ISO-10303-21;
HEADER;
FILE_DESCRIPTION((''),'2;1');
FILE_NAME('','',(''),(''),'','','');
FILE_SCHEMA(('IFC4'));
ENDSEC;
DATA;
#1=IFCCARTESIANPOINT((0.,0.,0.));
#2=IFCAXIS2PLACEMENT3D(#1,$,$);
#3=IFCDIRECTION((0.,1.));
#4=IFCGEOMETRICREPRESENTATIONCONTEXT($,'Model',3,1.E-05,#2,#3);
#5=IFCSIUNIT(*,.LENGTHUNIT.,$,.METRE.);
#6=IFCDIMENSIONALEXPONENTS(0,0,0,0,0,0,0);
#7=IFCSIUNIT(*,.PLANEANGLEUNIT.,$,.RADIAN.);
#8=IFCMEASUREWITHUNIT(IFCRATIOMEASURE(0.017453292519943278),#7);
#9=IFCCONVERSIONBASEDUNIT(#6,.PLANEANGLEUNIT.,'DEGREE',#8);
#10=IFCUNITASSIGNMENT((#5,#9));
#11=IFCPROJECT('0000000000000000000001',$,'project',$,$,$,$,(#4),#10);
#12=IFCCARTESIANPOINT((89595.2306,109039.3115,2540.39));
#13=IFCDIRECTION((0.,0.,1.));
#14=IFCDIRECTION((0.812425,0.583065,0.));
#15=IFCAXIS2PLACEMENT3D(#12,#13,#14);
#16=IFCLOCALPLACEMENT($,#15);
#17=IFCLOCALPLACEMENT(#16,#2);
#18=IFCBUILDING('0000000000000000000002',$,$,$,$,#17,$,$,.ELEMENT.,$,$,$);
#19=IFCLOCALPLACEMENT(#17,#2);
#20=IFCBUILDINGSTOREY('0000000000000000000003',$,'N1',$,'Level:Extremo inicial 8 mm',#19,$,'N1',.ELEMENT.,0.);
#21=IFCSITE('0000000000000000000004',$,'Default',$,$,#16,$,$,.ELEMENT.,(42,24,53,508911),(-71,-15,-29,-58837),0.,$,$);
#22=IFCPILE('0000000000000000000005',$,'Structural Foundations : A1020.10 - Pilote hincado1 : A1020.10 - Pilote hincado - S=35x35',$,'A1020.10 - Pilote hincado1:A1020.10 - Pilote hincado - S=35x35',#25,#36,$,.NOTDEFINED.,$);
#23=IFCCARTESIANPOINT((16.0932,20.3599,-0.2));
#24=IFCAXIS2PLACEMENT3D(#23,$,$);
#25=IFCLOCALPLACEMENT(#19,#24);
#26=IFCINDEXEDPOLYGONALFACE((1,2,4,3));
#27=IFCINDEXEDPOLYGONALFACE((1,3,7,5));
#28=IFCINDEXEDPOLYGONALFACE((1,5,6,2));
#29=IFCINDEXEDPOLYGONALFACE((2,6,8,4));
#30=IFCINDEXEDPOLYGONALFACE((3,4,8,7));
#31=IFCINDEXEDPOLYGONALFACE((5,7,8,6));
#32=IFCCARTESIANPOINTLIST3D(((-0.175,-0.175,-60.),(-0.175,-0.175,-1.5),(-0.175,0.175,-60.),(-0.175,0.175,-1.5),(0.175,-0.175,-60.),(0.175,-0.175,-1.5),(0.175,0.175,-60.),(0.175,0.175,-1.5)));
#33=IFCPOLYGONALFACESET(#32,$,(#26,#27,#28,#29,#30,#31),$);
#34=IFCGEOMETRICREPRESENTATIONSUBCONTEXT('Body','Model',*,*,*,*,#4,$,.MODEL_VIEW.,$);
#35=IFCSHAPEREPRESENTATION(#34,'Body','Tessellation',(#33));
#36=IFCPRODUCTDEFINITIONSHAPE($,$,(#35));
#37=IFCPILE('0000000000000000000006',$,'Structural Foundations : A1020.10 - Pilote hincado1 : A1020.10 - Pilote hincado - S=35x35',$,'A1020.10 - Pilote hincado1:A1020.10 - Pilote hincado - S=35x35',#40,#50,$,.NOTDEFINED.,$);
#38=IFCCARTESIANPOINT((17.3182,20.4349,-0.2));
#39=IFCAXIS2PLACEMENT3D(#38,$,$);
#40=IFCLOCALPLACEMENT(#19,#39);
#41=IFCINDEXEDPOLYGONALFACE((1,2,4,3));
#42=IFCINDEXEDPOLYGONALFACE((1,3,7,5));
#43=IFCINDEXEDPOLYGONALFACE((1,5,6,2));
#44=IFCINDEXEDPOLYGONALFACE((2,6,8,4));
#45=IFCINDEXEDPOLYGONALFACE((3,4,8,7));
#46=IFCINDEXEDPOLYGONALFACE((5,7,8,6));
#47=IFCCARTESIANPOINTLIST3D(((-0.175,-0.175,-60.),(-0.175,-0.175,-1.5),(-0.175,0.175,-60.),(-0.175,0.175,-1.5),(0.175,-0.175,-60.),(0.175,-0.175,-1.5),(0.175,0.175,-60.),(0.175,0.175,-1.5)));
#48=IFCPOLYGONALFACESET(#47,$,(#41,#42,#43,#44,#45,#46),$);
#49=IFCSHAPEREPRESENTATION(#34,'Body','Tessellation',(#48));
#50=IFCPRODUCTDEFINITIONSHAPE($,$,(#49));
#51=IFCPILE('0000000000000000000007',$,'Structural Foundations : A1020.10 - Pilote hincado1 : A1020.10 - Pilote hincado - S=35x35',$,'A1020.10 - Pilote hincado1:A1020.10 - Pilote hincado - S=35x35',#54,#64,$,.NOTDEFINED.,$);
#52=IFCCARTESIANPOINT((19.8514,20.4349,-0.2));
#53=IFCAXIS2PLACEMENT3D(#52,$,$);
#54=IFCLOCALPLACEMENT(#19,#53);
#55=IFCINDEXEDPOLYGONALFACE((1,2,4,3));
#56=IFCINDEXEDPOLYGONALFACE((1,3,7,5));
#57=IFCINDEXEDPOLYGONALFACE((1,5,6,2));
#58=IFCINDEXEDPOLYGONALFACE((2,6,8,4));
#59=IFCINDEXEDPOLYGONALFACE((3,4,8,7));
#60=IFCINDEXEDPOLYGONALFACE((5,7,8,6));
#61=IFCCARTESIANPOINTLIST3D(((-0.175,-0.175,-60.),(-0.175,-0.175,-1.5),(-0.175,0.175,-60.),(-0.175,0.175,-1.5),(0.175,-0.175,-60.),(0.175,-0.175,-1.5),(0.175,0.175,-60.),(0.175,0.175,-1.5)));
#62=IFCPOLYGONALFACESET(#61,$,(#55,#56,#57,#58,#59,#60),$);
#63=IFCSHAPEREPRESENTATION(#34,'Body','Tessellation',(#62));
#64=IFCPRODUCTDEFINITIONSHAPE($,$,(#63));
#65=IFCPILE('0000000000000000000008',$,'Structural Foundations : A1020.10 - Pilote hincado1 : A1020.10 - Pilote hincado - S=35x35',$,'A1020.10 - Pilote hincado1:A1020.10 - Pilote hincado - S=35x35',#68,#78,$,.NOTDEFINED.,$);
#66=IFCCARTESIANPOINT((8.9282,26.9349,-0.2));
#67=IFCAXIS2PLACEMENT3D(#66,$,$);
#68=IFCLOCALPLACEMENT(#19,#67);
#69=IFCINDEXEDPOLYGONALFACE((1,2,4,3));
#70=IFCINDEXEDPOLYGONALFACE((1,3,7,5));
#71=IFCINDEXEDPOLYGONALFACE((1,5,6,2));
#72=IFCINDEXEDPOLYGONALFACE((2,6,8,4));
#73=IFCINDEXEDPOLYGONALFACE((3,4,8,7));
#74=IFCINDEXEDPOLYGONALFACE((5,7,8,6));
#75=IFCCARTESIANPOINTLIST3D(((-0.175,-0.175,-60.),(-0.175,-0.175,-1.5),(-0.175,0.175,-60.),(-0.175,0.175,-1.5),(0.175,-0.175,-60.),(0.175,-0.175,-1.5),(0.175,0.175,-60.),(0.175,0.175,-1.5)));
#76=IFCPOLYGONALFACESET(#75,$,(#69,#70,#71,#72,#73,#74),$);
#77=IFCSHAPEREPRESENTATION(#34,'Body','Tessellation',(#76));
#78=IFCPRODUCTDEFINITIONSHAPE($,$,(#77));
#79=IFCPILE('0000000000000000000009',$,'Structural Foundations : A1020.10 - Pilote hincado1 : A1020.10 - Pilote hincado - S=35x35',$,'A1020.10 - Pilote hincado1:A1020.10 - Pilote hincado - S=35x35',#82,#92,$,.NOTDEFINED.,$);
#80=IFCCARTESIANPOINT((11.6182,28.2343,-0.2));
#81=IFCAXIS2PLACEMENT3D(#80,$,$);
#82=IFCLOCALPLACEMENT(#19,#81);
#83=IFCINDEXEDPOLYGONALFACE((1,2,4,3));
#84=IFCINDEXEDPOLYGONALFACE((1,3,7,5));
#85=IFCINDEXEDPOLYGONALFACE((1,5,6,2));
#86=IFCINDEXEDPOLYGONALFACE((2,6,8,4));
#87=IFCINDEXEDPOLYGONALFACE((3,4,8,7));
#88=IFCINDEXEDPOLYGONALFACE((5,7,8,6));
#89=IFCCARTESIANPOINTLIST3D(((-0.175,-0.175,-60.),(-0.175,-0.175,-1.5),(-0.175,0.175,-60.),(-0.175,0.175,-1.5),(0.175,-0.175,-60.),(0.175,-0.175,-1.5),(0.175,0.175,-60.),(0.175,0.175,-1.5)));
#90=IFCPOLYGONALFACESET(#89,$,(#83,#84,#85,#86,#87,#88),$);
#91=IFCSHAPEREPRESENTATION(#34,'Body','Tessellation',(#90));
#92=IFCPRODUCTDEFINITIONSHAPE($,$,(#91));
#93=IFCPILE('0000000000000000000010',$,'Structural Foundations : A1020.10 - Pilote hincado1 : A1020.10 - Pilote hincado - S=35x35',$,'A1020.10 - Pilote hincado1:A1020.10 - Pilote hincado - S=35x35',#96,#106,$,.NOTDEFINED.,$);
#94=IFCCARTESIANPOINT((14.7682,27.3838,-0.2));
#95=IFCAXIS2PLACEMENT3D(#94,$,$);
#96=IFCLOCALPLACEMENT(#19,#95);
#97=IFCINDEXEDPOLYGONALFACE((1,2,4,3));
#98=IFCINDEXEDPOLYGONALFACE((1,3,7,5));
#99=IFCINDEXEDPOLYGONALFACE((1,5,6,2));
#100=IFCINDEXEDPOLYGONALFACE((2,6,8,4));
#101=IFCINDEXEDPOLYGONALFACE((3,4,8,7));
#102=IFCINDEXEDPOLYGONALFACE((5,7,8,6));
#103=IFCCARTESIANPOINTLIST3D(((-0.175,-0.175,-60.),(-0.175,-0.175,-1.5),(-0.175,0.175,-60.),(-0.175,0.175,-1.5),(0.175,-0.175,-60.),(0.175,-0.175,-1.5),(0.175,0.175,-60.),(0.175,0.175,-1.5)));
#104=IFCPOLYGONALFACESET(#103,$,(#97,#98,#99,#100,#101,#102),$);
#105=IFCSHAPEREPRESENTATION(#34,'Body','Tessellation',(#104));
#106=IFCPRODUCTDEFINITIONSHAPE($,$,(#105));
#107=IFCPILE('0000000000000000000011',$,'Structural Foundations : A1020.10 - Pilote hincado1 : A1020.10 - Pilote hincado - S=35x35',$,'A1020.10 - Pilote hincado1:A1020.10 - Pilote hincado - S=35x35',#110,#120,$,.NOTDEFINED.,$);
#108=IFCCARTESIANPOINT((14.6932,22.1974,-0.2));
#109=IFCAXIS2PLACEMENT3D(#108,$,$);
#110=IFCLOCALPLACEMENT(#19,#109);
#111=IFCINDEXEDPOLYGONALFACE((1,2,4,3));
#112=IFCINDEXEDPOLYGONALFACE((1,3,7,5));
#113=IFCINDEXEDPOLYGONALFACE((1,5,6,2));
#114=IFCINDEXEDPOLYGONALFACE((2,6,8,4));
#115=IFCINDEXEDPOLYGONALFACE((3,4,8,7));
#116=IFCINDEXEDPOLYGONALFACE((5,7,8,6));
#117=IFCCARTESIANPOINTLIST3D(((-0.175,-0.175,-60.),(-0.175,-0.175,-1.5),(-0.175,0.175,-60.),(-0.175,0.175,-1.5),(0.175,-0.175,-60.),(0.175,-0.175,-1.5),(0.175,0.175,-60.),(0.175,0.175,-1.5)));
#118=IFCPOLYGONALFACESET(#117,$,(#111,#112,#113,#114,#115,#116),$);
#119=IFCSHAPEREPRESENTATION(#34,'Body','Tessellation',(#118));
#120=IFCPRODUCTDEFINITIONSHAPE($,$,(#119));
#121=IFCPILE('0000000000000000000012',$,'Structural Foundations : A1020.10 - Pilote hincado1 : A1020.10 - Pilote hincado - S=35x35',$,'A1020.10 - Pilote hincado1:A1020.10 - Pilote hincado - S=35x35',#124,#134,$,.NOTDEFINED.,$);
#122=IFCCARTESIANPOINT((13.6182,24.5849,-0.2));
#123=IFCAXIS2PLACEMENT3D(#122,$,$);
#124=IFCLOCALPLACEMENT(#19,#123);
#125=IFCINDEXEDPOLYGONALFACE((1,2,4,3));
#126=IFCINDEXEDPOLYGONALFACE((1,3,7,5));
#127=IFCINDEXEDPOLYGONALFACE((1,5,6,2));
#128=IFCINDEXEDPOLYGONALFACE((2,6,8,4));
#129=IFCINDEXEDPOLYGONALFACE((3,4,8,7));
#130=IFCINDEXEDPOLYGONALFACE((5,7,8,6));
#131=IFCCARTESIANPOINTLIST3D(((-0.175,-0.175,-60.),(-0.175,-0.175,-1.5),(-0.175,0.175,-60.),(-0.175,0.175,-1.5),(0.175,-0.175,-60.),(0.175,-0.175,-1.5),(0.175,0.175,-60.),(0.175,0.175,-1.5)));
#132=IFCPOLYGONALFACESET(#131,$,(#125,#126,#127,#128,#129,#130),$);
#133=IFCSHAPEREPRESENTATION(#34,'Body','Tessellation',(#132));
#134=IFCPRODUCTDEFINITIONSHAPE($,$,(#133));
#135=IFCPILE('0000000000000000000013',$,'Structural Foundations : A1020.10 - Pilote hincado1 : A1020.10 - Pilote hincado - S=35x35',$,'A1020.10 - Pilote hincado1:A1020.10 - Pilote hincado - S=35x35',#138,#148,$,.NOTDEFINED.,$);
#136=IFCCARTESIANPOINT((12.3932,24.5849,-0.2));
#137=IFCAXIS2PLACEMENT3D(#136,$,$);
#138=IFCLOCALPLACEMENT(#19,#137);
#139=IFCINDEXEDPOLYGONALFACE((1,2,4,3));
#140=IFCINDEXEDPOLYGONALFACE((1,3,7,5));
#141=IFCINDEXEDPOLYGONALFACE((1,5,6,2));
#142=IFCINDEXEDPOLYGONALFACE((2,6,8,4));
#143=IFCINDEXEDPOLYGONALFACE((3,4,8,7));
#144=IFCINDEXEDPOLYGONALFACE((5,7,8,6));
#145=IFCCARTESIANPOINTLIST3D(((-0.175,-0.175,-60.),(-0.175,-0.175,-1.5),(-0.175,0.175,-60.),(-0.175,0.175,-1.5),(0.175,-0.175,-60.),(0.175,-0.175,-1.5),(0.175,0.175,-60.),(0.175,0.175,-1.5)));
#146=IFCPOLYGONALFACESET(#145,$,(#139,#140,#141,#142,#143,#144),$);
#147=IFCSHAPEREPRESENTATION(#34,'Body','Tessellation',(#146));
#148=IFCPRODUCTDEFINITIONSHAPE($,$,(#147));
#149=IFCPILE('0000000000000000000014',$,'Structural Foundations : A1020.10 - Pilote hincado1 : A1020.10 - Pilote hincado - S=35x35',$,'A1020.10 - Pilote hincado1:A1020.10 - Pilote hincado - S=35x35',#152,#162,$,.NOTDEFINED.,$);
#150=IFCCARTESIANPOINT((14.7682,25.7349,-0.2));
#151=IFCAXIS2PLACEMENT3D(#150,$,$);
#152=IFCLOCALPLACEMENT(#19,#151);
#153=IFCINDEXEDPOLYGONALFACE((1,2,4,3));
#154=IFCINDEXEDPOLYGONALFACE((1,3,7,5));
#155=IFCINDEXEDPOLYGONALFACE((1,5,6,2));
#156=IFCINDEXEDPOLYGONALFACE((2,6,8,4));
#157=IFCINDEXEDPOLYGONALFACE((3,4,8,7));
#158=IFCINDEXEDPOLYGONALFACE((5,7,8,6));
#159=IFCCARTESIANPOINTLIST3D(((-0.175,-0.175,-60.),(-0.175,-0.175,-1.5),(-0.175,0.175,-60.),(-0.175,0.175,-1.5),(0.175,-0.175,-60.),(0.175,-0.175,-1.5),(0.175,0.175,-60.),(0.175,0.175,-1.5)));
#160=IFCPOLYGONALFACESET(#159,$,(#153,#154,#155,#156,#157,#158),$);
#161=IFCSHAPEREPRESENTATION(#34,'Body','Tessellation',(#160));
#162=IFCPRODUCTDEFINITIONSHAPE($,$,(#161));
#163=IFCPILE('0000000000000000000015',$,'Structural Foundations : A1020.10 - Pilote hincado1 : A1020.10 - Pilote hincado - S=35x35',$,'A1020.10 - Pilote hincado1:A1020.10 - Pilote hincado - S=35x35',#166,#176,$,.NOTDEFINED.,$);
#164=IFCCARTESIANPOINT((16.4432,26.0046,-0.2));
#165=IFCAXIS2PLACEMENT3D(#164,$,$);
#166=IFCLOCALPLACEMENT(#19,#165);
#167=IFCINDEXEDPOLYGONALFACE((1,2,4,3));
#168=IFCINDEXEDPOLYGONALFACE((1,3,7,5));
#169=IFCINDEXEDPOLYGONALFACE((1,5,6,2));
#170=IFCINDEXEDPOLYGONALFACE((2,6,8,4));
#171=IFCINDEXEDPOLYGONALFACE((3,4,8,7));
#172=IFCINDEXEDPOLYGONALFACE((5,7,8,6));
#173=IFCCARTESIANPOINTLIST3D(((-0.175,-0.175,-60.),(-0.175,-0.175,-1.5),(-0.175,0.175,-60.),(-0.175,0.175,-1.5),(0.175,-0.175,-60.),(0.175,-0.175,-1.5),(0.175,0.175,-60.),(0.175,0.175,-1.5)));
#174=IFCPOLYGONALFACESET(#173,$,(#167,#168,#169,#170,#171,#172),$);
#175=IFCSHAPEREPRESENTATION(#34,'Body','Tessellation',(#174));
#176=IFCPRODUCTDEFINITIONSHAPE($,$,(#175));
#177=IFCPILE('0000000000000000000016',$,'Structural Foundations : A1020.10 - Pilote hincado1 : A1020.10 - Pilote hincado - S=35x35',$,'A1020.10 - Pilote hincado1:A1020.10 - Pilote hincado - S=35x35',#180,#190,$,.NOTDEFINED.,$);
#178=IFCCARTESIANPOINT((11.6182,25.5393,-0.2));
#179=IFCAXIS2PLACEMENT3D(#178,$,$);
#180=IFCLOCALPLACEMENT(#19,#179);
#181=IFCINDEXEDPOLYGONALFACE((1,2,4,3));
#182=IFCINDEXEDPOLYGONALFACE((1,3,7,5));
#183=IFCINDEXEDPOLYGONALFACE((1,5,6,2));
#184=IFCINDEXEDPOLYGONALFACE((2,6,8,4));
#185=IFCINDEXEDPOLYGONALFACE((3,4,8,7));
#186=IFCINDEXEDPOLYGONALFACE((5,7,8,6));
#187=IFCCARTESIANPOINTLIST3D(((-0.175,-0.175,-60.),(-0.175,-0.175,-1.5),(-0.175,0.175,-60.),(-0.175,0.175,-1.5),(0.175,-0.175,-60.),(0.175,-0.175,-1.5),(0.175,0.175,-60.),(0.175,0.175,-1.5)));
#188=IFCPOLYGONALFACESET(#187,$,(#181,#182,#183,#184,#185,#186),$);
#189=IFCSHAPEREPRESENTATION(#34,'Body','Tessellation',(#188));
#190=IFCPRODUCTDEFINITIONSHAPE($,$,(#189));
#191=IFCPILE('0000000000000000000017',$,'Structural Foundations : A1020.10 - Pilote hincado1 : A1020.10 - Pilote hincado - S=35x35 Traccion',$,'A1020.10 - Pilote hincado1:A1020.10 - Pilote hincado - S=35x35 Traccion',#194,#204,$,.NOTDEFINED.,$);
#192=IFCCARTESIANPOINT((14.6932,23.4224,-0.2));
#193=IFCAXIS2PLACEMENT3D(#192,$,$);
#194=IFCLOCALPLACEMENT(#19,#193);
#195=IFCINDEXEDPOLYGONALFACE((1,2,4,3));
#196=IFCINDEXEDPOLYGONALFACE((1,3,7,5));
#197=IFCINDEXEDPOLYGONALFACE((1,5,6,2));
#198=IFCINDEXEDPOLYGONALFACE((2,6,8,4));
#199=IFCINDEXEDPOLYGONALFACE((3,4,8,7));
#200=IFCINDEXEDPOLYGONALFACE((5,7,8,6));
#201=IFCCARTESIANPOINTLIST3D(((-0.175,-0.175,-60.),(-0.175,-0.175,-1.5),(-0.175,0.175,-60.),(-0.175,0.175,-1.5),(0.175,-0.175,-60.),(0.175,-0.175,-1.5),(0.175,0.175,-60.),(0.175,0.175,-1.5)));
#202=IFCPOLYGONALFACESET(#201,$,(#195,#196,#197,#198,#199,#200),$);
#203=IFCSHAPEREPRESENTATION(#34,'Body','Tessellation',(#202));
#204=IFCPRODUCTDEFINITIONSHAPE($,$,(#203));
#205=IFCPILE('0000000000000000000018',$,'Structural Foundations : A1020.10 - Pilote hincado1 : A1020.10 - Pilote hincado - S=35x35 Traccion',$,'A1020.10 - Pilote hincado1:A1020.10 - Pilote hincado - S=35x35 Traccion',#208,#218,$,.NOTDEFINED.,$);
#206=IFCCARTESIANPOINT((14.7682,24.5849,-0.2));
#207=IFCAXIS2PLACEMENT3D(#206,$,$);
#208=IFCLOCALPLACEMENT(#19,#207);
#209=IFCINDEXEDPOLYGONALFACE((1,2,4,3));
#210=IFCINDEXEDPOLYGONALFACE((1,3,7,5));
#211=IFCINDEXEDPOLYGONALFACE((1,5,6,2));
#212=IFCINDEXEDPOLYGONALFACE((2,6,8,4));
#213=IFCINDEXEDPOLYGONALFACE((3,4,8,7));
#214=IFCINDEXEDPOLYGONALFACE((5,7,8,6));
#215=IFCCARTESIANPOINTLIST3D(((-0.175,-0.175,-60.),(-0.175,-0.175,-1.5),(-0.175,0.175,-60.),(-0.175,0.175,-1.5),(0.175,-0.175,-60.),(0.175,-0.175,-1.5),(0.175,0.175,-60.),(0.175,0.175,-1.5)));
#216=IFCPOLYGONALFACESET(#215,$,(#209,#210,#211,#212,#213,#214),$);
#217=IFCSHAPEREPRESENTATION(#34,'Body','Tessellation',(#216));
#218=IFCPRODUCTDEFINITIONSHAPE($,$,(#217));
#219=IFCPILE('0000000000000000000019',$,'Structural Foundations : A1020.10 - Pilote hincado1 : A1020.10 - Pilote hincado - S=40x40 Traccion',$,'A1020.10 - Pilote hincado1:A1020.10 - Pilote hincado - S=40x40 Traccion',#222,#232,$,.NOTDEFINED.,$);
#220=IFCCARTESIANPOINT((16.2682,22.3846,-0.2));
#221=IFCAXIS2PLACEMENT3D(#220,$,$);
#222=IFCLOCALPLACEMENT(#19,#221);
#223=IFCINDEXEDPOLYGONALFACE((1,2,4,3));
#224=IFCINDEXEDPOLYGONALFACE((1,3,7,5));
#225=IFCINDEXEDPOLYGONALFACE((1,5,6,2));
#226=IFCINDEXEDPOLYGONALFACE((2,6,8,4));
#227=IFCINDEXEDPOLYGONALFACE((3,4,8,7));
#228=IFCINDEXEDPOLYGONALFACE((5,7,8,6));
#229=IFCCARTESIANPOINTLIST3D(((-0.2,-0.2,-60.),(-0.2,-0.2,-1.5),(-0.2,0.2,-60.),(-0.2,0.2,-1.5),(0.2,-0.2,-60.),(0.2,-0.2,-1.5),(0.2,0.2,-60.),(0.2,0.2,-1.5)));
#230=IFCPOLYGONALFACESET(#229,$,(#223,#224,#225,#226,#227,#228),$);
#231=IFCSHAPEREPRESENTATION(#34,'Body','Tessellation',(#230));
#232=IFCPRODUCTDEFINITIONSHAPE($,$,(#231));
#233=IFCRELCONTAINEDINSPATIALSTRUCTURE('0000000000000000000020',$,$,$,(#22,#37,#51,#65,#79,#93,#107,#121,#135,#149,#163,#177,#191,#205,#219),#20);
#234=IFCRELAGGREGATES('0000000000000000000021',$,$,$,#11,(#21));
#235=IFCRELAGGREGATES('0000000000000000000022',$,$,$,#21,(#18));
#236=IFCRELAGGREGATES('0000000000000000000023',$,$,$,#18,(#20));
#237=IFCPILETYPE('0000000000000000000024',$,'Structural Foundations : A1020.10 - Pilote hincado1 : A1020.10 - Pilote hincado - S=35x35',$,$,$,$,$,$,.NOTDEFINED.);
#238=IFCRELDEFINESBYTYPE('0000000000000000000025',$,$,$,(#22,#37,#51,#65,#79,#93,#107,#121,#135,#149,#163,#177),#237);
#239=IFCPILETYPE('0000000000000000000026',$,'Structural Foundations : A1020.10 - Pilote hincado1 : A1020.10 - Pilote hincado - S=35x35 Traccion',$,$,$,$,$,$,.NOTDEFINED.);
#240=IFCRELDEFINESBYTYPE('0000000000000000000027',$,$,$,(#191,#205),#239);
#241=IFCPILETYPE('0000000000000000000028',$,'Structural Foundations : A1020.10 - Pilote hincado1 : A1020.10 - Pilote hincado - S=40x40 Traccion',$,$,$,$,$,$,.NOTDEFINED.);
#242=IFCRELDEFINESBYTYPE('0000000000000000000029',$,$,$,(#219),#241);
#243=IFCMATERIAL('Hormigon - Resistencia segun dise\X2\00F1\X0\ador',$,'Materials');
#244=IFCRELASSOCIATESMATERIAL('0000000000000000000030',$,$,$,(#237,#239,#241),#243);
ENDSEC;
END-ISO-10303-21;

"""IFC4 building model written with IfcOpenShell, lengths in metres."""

from ifc_helpers import new_model, entity, si_unit, converted_unit, direction, frame, origin, origin_2d_with_axis, place, context, subcontext, project, spatial, polyline, segment, composite_curve, rectangle, outline, extrude, source, transform, mapped, material, material_profile, profile_set, type_object, type_shapes, element, save


model = new_model("IFC4")

# Units and contexts
model_context = context("Model", 3, precision=1e-05, world=origin(), true_north=direction((0.0, 1.0)))
body_context = subcontext(model_context, "Body", "Model", "MODEL_VIEW")
ifc_project = project(units=[si_unit("LENGTHUNIT", "METRE"), converted_unit("PLANEANGLEUNIT", "DEGREE", entity("IfcRatioMeasure", 0.017453292519943278), si_unit("PLANEANGLEUNIT", "RADIAN"), dimensions=[0, 0, 0, 0, 0, 0, 0])], contexts=[model_context])

# Site, building, storey
site_placement = place(None, frame((89595.2306, 109039.3115, 2540.39), z_axis=(0.0, 0.0, 1.0), x_axis=(0.812425, 0.583065, 0.0)))
site = spatial("IfcSite", under=ifc_project, at=site_placement, Name="Default", CompositionType="ELEMENT", RefLatitude=(42, 24, 53, 508911), RefLongitude=(-71, -15, -29, -58837), RefElevation=0.0)
building_placement = place(site_placement, origin())
building = spatial("IfcBuilding", under=site, at=building_placement, CompositionType="ELEMENT")
storey_placement = place(building_placement, origin())
storey = spatial("IfcBuildingStorey", under=building, at=storey_placement, Name="N1", ObjectType="Level:Extremo inicial 8 mm", LongName="N1", CompositionType="ELEMENT", Elevation=0.0)

# Piles
ifc_material_1 = material(Name="Hormigon - Resistencia segun diseñador", Category="Materials")
ifc_material_profile_1 = material_profile(ifc_material_1, outline(composite_curve([segment(polyline([(0.175, -0.175, -60.0), (-0.175, -0.175, -60.0)]), True, "CONTINUOUS"), segment(polyline([(-0.175, -0.175, -60.0), (-0.175, 0.175, -60.0)]), True, "CONTINUOUS"), segment(polyline([(-0.175, 0.175, -60.0), (0.175, 0.175, -60.0)]), True, "CONTINUOUS"), segment(polyline([(0.175, 0.175, -60.0), (0.175, -0.175, -60.0)]), True, "CONTINUOUS")], self_intersect=False), kind="CURVE"), Name="A1020.10 - Pilote hincado - S=35x35")
ifc_profile_set_1 = profile_set([ifc_material_profile_1], Name="A1020.10 - Pilote hincado - S=35x35")
pile_type_1 = type_object("IfcPileType", Name="Structural Foundations : A1020.10 - Pilote hincado1 : A1020.10 - Pilote hincado - S=35x35", PredefinedType="NOTDEFINED", material=ifc_profile_set_1)
shared_shape_1 = source(origin(), body_context, "Body", "SweptSolid", [
    extrude(rectangle(XDim=0.35, YDim=0.35, at=origin_2d_with_axis()), frame((0.0, 0.0, -60.0), z_axis=(0.0, 0.0, 1.0), x_axis=(0.0, -1.0, 0.0)), (0.0, 0.0, 1.0), 58.5),
])
type_shapes(pile_type_1, [shared_shape_1])
for number, where, name in (
    (1, (16.0932, 20.3599, -0.2), "Structural Foundations : A1020.10 - Pilote hincado1 : A1020.10 - Pilote hincado - S=35x35"),
    (2, (17.3182, 20.4349, -0.2), "Structural Foundations : A1020.10 - Pilote hincado1 : A1020.10 - Pilote hincado - S=35x35"),
    (3, (19.8514, 20.4349, -0.2), "Structural Foundations : A1020.10 - Pilote hincado1 : A1020.10 - Pilote hincado - S=35x35"),
    (4, (8.9282, 26.9349, -0.2), "Structural Foundations : A1020.10 - Pilote hincado1 : A1020.10 - Pilote hincado - S=35x35"),
    (5, (11.6182, 28.2343, -0.2), "Structural Foundations : A1020.10 - Pilote hincado1 : A1020.10 - Pilote hincado - S=35x35"),
    (6, (14.7682, 27.3838, -0.2), "Structural Foundations : A1020.10 - Pilote hincado1 : A1020.10 - Pilote hincado - S=35x35"),
    (7, (14.6932, 22.1974, -0.2), "Structural Foundations : A1020.10 - Pilote hincado1 : A1020.10 - Pilote hincado - S=35x35"),
    (8, (13.6182, 24.5849, -0.2), "Structural Foundations : A1020.10 - Pilote hincado1 : A1020.10 - Pilote hincado - S=35x35"),
    (9, (12.3932, 24.5849, -0.2), "Structural Foundations : A1020.10 - Pilote hincado1 : A1020.10 - Pilote hincado - S=35x35"),
    (10, (14.7682, 25.7349, -0.2), "Structural Foundations : A1020.10 - Pilote hincado1 : A1020.10 - Pilote hincado - S=35x35"),
    (11, (16.4432, 26.0046, -0.2), "Structural Foundations : A1020.10 - Pilote hincado1 : A1020.10 - Pilote hincado - S=35x35"),
    (12, (11.6182, 25.5393, -0.2), "Structural Foundations : A1020.10 - Pilote hincado1 : A1020.10 - Pilote hincado - S=35x35"),
):
    element("IfcPile", number, at=place(storey_placement, frame(where)), inside=storey, type_object=pile_type_1, Name=name, ObjectType="A1020.10 - Pilote hincado1:A1020.10 - Pilote hincado - S=35x35", PredefinedType="NOTDEFINED", context=body_context, shape_type="MappedRepresentation", body=[
        mapped(shared_shape_1, transform((0.0, 0.0, 0.0), scale=1.0)),
    ])
ifc_material_profile_2 = material_profile(ifc_material_1, outline(composite_curve([segment(polyline([(0.175, -0.175, -60.0), (-0.175, -0.175, -60.0)]), True, "CONTINUOUS"), segment(polyline([(-0.175, -0.175, -60.0), (-0.175, 0.175, -60.0)]), True, "CONTINUOUS"), segment(polyline([(-0.175, 0.175, -60.0), (0.175, 0.175, -60.0)]), True, "CONTINUOUS"), segment(polyline([(0.175, 0.175, -60.0), (0.175, -0.175, -60.0)]), True, "CONTINUOUS")], self_intersect=False), kind="CURVE"), Name="A1020.10 - Pilote hincado - S=35x35 Traccion")
ifc_profile_set_2 = profile_set([ifc_material_profile_2], Name="A1020.10 - Pilote hincado - S=35x35 Traccion")
pile_type_2 = type_object("IfcPileType", Name="Structural Foundations : A1020.10 - Pilote hincado1 : A1020.10 - Pilote hincado - S=35x35 Traccion", PredefinedType="NOTDEFINED", material=ifc_profile_set_2)
shared_shape_2 = source(origin(), body_context, "Body", "SweptSolid", [
    extrude(rectangle(XDim=0.35, YDim=0.35, at=origin_2d_with_axis()), frame((0.0, 0.0, -60.0), z_axis=(0.0, 0.0, 1.0), x_axis=(0.0, -1.0, 0.0)), (0.0, 0.0, 1.0), 58.5),
])
type_shapes(pile_type_2, [shared_shape_2])
for number, where, name in (
    (13, (14.6932, 23.4224, -0.2), "Structural Foundations : A1020.10 - Pilote hincado1 : A1020.10 - Pilote hincado - S=35x35 Traccion"),
    (14, (14.7682, 24.5849, -0.2), "Structural Foundations : A1020.10 - Pilote hincado1 : A1020.10 - Pilote hincado - S=35x35 Traccion"),
):
    element("IfcPile", number, at=place(storey_placement, frame(where)), inside=storey, type_object=pile_type_2, Name=name, ObjectType="A1020.10 - Pilote hincado1:A1020.10 - Pilote hincado - S=35x35 Traccion", PredefinedType="NOTDEFINED", context=body_context, shape_type="MappedRepresentation", body=[
        mapped(shared_shape_2, transform((0.0, 0.0, 0.0), scale=1.0)),
    ])
ifc_material_profile_3 = material_profile(ifc_material_1, outline(composite_curve([segment(polyline([(0.2, -0.2, -1.5), (0.2, 0.2, -1.5)]), True, "CONTINUOUS"), segment(polyline([(0.2, 0.2, -1.5), (-0.2, 0.2, -1.5)]), True, "CONTINUOUS"), segment(polyline([(-0.2, 0.2, -1.5), (-0.2, -0.2, -1.5)]), True, "CONTINUOUS"), segment(polyline([(-0.2, -0.2, -1.5), (0.2, -0.2, -1.5)]), True, "CONTINUOUS")], self_intersect=False), kind="CURVE"), Name="A1020.10 - Pilote hincado - S=40x40 Traccion")
ifc_profile_set_3 = profile_set([ifc_material_profile_3], Name="A1020.10 - Pilote hincado - S=40x40 Traccion")
pile_type_3 = type_object("IfcPileType", Name="Structural Foundations : A1020.10 - Pilote hincado1 : A1020.10 - Pilote hincado - S=40x40 Traccion", PredefinedType="NOTDEFINED", material=ifc_profile_set_3)
shared_shape_3 = source(origin(), body_context, "Body", "SweptSolid", [
    extrude(rectangle(XDim=0.4, YDim=0.4, at=origin_2d_with_axis()), frame((0.0, 0.0, -60.0), z_axis=(0.0, 0.0, 1.0), x_axis=(0.0, -1.0, 0.0)), (0.0, 0.0, 1.0), 58.5),
])
type_shapes(pile_type_3, [shared_shape_3])
for number, where, name in (
    (15, (16.2682, 22.3846, -0.2), "Structural Foundations : A1020.10 - Pilote hincado1 : A1020.10 - Pilote hincado - S=40x40 Traccion"),
):
    element("IfcPile", number, at=place(storey_placement, frame(where)), inside=storey, type_object=pile_type_3, Name=name, ObjectType="A1020.10 - Pilote hincado1:A1020.10 - Pilote hincado - S=40x40 Traccion", PredefinedType="NOTDEFINED", context=body_context, shape_type="MappedRepresentation", body=[
        mapped(shared_shape_3, transform((0.0, 0.0, 0.0), scale=1.0)),
    ])

save(model, "model.ifc")
